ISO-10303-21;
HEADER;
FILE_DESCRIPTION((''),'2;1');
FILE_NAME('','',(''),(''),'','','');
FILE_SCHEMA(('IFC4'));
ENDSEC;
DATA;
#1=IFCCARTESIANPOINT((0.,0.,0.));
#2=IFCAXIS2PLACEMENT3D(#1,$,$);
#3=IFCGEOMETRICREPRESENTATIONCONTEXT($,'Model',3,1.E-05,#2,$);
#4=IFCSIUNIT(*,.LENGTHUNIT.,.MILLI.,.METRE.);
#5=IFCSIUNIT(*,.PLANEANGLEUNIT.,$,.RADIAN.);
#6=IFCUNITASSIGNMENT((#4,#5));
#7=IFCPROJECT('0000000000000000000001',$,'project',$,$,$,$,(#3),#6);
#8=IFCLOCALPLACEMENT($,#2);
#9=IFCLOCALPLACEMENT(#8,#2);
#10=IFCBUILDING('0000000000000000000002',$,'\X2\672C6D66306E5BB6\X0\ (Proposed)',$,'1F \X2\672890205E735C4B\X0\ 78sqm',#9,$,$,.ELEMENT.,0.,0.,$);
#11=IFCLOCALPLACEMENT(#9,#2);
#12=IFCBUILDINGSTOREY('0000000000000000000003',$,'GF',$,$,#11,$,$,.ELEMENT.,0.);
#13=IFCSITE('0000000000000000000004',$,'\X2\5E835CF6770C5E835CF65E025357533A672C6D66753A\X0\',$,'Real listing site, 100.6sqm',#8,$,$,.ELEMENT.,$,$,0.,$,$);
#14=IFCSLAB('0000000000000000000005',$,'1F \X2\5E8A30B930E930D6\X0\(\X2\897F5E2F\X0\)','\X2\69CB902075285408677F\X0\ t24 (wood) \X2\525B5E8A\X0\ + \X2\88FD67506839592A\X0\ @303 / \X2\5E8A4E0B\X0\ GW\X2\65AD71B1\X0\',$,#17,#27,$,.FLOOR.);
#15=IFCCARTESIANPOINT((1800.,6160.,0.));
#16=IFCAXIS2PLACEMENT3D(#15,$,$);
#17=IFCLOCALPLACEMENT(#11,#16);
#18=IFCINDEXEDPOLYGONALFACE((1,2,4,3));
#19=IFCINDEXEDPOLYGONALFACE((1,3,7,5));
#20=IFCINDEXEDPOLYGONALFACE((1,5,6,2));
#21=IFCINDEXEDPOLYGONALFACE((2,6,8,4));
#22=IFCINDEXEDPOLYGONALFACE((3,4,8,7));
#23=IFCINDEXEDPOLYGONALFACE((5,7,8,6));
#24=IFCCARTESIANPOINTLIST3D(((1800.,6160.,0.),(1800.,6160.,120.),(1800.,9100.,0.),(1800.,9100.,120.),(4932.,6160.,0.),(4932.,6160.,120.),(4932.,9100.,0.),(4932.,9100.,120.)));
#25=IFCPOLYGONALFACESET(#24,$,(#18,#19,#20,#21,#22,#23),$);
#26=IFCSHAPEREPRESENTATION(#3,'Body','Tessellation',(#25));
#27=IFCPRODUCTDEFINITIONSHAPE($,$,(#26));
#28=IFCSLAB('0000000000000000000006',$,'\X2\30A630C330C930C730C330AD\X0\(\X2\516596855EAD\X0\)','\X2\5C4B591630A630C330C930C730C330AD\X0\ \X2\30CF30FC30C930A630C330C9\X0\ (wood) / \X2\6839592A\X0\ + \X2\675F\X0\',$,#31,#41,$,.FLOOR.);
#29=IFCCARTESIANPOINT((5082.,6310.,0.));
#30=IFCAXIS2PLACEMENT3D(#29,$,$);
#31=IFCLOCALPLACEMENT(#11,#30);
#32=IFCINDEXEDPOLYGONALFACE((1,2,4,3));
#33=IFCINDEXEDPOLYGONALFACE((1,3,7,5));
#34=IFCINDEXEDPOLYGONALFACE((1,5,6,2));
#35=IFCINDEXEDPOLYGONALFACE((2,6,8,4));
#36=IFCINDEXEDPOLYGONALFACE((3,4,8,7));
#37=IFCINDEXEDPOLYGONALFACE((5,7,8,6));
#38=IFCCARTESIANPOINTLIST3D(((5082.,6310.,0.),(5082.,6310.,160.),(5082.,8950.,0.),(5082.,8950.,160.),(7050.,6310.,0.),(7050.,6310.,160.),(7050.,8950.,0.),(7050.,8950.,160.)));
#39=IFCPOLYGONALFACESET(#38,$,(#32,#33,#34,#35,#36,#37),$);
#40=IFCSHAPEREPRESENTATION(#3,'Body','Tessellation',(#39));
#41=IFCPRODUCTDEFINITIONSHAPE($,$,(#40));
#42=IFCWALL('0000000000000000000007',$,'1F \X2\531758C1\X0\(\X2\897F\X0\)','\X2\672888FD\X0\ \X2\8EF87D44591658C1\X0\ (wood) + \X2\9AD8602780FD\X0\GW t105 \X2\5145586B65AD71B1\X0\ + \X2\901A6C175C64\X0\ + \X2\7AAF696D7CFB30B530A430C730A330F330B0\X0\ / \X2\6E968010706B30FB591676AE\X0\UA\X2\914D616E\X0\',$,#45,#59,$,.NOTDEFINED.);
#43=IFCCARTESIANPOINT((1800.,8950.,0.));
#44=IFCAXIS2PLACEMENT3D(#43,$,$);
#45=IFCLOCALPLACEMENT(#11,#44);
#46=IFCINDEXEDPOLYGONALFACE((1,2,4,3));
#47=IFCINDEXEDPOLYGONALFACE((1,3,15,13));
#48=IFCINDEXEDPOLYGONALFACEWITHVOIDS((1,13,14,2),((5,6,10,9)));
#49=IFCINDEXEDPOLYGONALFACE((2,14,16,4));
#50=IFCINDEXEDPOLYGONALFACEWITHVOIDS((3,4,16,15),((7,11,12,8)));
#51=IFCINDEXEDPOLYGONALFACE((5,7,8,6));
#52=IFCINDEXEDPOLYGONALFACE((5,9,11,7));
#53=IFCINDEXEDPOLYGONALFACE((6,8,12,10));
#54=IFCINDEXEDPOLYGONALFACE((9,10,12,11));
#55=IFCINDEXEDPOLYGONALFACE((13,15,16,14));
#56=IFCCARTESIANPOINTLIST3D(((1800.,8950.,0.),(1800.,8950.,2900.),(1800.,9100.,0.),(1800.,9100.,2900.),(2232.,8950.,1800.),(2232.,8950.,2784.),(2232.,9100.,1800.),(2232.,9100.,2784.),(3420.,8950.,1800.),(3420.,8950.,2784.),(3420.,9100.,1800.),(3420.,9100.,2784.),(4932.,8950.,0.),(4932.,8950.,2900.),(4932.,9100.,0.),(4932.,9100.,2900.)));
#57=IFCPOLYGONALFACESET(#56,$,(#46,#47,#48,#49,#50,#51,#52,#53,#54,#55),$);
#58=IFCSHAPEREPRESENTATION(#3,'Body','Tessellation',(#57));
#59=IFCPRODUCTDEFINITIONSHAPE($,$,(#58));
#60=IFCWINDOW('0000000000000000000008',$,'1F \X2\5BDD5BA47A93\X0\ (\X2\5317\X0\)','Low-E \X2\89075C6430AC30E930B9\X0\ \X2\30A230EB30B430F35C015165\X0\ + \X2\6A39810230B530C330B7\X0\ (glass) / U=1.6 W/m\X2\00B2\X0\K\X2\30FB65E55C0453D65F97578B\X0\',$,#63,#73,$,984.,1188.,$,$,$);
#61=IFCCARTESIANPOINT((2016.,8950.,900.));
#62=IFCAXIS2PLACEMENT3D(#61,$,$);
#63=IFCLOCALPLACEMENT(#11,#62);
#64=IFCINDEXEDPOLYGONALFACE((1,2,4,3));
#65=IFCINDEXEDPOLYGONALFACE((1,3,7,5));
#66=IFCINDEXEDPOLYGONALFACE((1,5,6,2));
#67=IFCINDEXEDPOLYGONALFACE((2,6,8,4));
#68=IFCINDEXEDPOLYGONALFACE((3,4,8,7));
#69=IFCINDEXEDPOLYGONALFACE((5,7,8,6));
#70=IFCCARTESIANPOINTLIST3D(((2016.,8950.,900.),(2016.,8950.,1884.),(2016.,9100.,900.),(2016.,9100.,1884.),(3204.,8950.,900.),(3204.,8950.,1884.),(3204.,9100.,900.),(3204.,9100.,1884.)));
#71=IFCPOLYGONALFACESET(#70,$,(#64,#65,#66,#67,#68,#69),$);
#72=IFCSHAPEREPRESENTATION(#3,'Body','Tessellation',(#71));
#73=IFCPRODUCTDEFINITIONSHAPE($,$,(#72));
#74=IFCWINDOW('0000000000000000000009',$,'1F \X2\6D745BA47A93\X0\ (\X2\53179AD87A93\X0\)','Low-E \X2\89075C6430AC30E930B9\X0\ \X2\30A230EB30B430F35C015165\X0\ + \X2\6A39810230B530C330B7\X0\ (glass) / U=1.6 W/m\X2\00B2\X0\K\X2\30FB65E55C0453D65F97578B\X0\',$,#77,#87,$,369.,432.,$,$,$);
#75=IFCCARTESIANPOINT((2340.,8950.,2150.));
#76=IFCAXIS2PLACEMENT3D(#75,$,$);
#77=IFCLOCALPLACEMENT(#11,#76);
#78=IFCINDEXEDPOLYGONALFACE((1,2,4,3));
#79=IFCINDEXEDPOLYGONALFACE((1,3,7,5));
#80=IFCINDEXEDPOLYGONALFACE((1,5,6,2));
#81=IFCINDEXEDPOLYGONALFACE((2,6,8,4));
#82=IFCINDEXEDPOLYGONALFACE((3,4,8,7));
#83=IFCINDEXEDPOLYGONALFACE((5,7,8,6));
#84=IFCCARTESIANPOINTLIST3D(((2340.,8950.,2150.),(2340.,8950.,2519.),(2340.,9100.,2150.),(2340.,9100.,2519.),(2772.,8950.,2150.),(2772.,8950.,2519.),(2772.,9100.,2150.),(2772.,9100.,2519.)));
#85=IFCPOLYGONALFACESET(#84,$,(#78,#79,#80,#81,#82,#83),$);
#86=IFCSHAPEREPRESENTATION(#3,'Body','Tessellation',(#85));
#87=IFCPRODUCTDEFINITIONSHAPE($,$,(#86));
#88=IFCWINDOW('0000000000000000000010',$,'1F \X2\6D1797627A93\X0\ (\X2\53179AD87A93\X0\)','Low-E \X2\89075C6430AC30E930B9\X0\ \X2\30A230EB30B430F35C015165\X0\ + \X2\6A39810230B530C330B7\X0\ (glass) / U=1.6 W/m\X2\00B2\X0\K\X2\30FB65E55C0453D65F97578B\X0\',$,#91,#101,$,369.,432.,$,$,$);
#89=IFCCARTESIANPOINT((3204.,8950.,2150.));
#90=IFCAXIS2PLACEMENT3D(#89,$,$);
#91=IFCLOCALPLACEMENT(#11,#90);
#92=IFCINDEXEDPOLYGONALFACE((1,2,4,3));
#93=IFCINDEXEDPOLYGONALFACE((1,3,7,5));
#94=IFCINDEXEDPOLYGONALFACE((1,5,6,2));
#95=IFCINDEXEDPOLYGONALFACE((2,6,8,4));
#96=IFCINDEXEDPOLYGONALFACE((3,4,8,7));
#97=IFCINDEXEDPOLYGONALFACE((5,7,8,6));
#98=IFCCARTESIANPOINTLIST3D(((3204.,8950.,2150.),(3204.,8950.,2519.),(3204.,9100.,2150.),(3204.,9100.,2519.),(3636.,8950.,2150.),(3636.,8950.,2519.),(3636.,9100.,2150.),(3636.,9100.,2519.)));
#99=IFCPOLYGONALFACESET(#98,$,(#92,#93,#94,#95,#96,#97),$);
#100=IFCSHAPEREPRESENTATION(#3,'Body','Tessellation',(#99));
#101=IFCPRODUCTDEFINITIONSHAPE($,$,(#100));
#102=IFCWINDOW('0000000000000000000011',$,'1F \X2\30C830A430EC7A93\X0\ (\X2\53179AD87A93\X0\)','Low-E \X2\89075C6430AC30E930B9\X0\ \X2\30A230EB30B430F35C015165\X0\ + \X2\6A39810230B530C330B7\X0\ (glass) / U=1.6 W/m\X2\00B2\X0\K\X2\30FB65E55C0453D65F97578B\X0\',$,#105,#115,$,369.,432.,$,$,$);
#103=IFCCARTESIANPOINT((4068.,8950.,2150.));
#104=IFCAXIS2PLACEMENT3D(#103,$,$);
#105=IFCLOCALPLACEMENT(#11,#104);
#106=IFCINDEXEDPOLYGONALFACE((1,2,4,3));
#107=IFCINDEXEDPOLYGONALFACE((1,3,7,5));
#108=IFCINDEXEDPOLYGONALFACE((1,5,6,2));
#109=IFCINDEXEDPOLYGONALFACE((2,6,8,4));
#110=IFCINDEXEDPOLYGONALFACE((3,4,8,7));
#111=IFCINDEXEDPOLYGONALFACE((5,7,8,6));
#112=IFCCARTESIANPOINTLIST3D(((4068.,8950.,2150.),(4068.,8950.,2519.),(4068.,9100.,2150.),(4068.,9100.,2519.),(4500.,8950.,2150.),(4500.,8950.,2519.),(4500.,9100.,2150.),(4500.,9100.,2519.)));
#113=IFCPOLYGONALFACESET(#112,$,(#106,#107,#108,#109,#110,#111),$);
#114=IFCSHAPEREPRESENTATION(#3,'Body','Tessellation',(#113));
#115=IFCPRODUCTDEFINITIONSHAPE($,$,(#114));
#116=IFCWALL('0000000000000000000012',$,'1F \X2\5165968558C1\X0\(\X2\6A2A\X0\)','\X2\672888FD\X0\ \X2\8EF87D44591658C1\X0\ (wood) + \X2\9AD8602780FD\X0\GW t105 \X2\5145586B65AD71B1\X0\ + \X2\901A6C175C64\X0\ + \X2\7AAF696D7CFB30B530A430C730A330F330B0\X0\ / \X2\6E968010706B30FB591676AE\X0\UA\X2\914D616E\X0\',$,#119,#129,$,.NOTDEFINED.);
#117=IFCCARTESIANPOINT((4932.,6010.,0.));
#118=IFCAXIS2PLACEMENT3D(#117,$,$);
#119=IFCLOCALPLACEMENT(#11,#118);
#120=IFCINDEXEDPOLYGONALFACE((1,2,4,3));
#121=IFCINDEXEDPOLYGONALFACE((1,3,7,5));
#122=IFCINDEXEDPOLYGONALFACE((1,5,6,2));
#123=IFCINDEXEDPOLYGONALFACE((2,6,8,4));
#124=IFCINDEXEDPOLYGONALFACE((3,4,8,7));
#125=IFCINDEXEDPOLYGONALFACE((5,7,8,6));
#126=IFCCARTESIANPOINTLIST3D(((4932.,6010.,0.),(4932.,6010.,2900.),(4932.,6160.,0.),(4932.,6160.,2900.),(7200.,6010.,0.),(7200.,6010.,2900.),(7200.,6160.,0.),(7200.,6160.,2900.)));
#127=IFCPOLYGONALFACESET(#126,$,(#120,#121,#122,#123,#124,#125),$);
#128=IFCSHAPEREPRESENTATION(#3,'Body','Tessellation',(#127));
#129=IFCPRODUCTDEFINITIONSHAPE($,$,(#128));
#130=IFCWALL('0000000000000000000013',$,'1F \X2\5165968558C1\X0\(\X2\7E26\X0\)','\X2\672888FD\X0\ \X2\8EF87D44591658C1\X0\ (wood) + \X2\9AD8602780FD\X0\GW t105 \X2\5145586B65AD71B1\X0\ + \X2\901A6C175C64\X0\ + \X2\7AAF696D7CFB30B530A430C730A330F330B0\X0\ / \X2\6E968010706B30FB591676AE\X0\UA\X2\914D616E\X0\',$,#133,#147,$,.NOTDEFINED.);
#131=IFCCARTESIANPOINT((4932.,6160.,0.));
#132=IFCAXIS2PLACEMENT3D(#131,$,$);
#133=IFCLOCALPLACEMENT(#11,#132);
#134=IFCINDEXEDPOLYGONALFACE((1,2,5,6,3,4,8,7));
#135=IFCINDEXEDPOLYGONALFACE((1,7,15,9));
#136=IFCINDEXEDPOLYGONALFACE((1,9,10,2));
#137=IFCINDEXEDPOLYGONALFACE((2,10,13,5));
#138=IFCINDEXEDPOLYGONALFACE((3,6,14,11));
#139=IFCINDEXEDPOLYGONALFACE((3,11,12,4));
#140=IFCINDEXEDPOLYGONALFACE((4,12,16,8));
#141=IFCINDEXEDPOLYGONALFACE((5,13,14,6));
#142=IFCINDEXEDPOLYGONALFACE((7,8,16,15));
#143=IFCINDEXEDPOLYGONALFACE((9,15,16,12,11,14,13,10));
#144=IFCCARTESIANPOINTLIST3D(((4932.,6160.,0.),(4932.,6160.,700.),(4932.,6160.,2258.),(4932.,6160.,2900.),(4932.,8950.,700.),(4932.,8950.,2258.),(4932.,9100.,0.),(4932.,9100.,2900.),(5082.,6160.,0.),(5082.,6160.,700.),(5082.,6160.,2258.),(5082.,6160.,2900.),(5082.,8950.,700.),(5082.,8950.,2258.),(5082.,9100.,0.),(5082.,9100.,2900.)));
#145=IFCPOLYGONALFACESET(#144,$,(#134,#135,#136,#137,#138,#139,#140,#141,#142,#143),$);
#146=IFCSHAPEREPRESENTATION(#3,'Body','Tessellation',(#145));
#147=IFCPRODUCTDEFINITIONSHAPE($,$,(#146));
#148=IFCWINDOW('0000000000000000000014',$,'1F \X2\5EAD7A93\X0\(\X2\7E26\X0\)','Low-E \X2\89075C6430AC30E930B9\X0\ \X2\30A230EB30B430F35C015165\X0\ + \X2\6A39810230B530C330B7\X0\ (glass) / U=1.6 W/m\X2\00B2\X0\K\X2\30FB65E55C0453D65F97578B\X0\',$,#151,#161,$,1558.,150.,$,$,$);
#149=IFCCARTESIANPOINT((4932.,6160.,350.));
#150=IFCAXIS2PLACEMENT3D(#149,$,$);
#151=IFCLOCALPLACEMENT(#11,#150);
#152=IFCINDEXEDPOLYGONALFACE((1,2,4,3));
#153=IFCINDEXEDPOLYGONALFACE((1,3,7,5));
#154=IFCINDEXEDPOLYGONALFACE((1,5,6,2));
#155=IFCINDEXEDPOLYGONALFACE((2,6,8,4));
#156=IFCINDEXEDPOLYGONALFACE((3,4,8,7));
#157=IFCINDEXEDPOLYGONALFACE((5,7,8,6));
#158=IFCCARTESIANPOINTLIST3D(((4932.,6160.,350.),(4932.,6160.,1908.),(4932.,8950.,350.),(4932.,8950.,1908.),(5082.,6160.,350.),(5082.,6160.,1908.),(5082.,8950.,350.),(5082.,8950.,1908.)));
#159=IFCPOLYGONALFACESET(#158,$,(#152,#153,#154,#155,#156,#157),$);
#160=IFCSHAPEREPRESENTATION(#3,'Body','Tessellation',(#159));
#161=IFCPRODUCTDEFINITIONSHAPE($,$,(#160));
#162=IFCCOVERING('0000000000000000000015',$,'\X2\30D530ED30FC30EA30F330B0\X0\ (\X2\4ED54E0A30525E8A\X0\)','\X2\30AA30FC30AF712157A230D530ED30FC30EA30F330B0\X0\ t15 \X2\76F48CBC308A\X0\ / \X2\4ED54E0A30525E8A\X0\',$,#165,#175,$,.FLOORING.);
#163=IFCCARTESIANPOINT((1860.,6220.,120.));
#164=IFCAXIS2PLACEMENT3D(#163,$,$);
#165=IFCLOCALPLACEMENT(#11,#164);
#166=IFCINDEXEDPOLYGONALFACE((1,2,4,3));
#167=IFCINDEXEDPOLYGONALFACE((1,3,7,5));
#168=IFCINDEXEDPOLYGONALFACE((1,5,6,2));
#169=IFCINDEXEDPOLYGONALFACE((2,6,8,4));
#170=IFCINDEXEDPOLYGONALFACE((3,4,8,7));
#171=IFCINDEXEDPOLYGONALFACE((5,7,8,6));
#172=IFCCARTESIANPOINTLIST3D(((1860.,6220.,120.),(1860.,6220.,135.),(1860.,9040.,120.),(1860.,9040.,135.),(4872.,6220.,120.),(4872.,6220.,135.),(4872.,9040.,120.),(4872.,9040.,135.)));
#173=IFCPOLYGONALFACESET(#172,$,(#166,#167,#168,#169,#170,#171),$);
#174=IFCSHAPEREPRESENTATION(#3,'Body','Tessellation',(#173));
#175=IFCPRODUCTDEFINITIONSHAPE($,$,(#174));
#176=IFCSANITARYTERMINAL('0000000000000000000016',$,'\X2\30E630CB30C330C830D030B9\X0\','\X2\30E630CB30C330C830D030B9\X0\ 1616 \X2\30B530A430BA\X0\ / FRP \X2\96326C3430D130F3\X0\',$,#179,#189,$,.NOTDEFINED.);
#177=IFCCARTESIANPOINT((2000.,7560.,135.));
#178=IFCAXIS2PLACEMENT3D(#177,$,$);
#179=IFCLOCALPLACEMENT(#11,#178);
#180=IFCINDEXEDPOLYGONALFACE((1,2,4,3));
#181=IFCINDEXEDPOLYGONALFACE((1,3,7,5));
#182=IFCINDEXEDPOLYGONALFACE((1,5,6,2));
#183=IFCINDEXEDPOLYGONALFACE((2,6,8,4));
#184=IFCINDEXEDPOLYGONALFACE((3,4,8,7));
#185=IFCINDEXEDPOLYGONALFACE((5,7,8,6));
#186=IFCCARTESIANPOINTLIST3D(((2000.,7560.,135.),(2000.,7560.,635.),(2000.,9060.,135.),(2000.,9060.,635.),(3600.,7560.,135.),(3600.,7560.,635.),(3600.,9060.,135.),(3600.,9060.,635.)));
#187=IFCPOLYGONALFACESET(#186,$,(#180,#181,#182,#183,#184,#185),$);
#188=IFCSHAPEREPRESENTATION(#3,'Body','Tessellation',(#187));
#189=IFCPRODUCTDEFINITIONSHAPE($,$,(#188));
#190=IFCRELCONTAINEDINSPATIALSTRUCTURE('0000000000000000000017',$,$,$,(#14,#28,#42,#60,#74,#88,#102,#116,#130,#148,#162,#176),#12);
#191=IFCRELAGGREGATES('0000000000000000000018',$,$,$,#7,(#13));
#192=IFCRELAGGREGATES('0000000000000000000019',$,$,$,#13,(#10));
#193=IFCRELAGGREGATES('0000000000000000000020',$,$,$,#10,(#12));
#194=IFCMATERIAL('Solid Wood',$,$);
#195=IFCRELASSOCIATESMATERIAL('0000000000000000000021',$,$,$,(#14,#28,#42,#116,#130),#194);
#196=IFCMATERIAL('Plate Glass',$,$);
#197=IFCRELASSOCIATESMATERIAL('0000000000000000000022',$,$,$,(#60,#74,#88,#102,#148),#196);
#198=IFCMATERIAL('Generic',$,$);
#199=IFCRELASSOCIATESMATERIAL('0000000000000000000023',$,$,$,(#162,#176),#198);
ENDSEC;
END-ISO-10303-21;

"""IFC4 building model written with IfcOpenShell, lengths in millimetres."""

from ifc_helpers import new_model, si_unit, frame, frame_2d, origin, place, context, project, spatial, rectangle, extrude, material, element, fill, save


model = new_model("IFC4")

# Units and contexts
model_context = context("Model", 3, precision=1e-05, world=origin())
ifc_project = project(units=[si_unit("LENGTHUNIT", "METRE", prefix="MILLI"), si_unit("PLANEANGLEUNIT", "RADIAN")], contexts=[model_context])

# Site, building, storey
site_placement = place(None, origin())
site = spatial("IfcSite", under=ifc_project, at=site_placement, Name="広島県広島市南区本浦町", ObjectType="Real listing site, 100.6sqm", CompositionType="ELEMENT", RefElevation=0.0)
building_placement = place(site_placement, origin())
building = spatial("IfcBuilding", under=site, at=building_placement, Name="本浦の家 (Proposed)", ObjectType="1F 木造平屋 78sqm", CompositionType="ELEMENT", ElevationOfRefHeight=0.0, ElevationOfTerrain=0.0)
storey_placement = place(building_placement, origin())
storey = spatial("IfcBuildingStorey", under=building, at=storey_placement, Name="GF", CompositionType="ELEMENT", Elevation=0.0)

# Slabs
ifc_material_1 = material(Name="Solid Wood")
slab_1_placement = place(storey_placement, frame((1800.0, 6160.0, 0.0)))
element("IfcSlab", 1, at=slab_1_placement, inside=storey, material=ifc_material_1, Name="1F 床スラブ(西帯)", Description="構造用合板 t24 (wood) 剛床 + 製材根太 @303 / 床下 GW断熱", PredefinedType="FLOOR", context=model_context, shape_type="SweptSolid", body=[
    extrude(rectangle(XDim=3132.0, YDim=2940.0, at=frame_2d((1566.0, 1470.0))), frame((1800.0, 6160.0, 0.0)), (0.0, 0.0, 1.0), 120.0),
])
slab_2_placement = place(storey_placement, frame((5082.0, 6310.0, 0.0)))
element("IfcSlab", 2, at=slab_2_placement, inside=storey, material=ifc_material_1, Name="ウッドデッキ(入隅庭)", Description="屋外ウッドデッキ ハードウッド (wood) / 根太 + 束", PredefinedType="FLOOR", context=model_context, shape_type="SweptSolid", body=[
    extrude(rectangle(XDim=1968.0, YDim=2640.0, at=frame_2d((984.0, 1320.0))), frame((5082.0, 6310.0, 0.0)), (0.0, 0.0, 1.0), 160.0),
])

# Wall, openings, windows
wall_1_placement = place(storey_placement, frame((1800.0, 8950.0, 0.0)))
wall_1 = element("IfcWall", 3, at=wall_1_placement, inside=storey, material=ifc_material_1, Name="1F 北壁(西)", Description="木製 軸組外壁 (wood) + 高性能GW t105 充填断熱 + 通気層 + 窯業系サイディング / 準耐火・外皮UA配慮", PredefinedType="NOTDEFINED", context=model_context, shape_type="SweptSolid", body=[
    extrude(rectangle(XDim=3132.0, YDim=150.0, at=frame_2d((1566.0, 75.0))), frame((1800.0, 8950.0, 0.0)), (0.0, 0.0, 1.0), 2900.0),
])
opening_1_placement = place(storey_placement, frame((2016.0, 8950.0, 900.0)))
opening_1 = element("IfcOpeningElement", 4, at=opening_1_placement, cuts=wall_1, PredefinedType="NOTDEFINED", context=model_context, shape_type="SweptSolid", body=[
    extrude(rectangle(XDim=1188.0, YDim=150.0, at=frame_2d((594.0, 75.0))), frame((2016.0, 8950.0, 900.0)), (0.0, 0.0, 1.0), 984.0),
])
opening_2_placement = place(storey_placement, frame((2340.0, 8950.0, 2150.0)))
opening_2 = element("IfcOpeningElement", 5, at=opening_2_placement, cuts=wall_1, PredefinedType="NOTDEFINED", context=model_context, shape_type="SweptSolid", body=[
    extrude(rectangle(XDim=432.0, YDim=150.0, at=frame_2d((216.0, 75.0))), frame((2340.0, 8950.0, 2150.0)), (0.0, 0.0, 1.0), 369.0),
])
opening_3_placement = place(storey_placement, frame((3204.0, 8950.0, 2150.0)))
opening_3 = element("IfcOpeningElement", 6, at=opening_3_placement, cuts=wall_1, PredefinedType="NOTDEFINED", context=model_context, shape_type="SweptSolid", body=[
    extrude(rectangle(XDim=432.0, YDim=150.0, at=frame_2d((216.0, 75.0))), frame((3204.0, 8950.0, 2150.0)), (0.0, 0.0, 1.0), 369.0),
])
opening_4_placement = place(storey_placement, frame((4068.0, 8950.0, 2150.0)))
opening_4 = element("IfcOpeningElement", 7, at=opening_4_placement, cuts=wall_1, PredefinedType="NOTDEFINED", context=model_context, shape_type="SweptSolid", body=[
    extrude(rectangle(XDim=432.0, YDim=150.0, at=frame_2d((216.0, 75.0))), frame((4068.0, 8950.0, 2150.0)), (0.0, 0.0, 1.0), 369.0),
])
ifc_material_2 = material(Name="Plate Glass")
window_1_placement = place(storey_placement, frame((2016.0, 8950.0, 900.0)))
window_1 = element("IfcWindow", 8, at=window_1_placement, inside=storey, material=ifc_material_2, Name="1F 寝室窓 (北)", Description="Low-E 複層ガラス アルゴン封入 + 樹脂サッシ (glass) / U=1.6 W/m²K・日射取得型", OverallHeight=984.0, OverallWidth=1188.0, context=model_context, shape_type="SweptSolid", body=[
    extrude(rectangle(XDim=1188.0, YDim=150.0, at=frame_2d((594.0, 75.0))), frame((2016.0, 8950.0, 900.0)), (0.0, 0.0, 1.0), 984.0),
])
fill(opening_1, window_1)
window_2_placement = place(storey_placement, frame((2340.0, 8950.0, 2150.0)))
window_2 = element("IfcWindow", 9, at=window_2_placement, inside=storey, material=ifc_material_2, Name="1F 浴室窓 (北高窓)", Description="Low-E 複層ガラス アルゴン封入 + 樹脂サッシ (glass) / U=1.6 W/m²K・日射取得型", OverallHeight=369.0, OverallWidth=432.0, context=model_context, shape_type="SweptSolid", body=[
    extrude(rectangle(XDim=432.0, YDim=150.0, at=frame_2d((216.0, 75.0))), frame((2340.0, 8950.0, 2150.0)), (0.0, 0.0, 1.0), 369.0),
])
fill(opening_2, window_2)
window_3_placement = place(storey_placement, frame((3204.0, 8950.0, 2150.0)))
window_3 = element("IfcWindow", 10, at=window_3_placement, inside=storey, material=ifc_material_2, Name="1F 洗面窓 (北高窓)", Description="Low-E 複層ガラス アルゴン封入 + 樹脂サッシ (glass) / U=1.6 W/m²K・日射取得型", OverallHeight=369.0, OverallWidth=432.0, context=model_context, shape_type="SweptSolid", body=[
    extrude(rectangle(XDim=432.0, YDim=150.0, at=frame_2d((216.0, 75.0))), frame((3204.0, 8950.0, 2150.0)), (0.0, 0.0, 1.0), 369.0),
])
fill(opening_3, window_3)
window_4_placement = place(storey_placement, frame((4068.0, 8950.0, 2150.0)))
window_4 = element("IfcWindow", 11, at=window_4_placement, inside=storey, material=ifc_material_2, Name="1F トイレ窓 (北高窓)", Description="Low-E 複層ガラス アルゴン封入 + 樹脂サッシ (glass) / U=1.6 W/m²K・日射取得型", OverallHeight=369.0, OverallWidth=432.0, context=model_context, shape_type="SweptSolid", body=[
    extrude(rectangle(XDim=432.0, YDim=150.0, at=frame_2d((216.0, 75.0))), frame((4068.0, 8950.0, 2150.0)), (0.0, 0.0, 1.0), 369.0),
])
fill(opening_4, window_4)

# Wall
wall_2_placement = place(storey_placement, frame((4932.0, 6010.0, 0.0)))
element("IfcWall", 12, at=wall_2_placement, inside=storey, material=ifc_material_1, Name="1F 入隅壁(横)", Description="木製 軸組外壁 (wood) + 高性能GW t105 充填断熱 + 通気層 + 窯業系サイディング / 準耐火・外皮UA配慮", PredefinedType="NOTDEFINED", context=model_context, shape_type="SweptSolid", body=[
    extrude(rectangle(XDim=2268.0, YDim=150.0, at=frame_2d((1134.0, 75.0))), frame((4932.0, 6010.0, 0.0)), (0.0, 0.0, 1.0), 2900.0),
])

# Wall, opening, window
wall_3_placement = place(storey_placement, frame((4932.0, 6160.0, 0.0)))
wall_3 = element("IfcWall", 13, at=wall_3_placement, inside=storey, material=ifc_material_1, Name="1F 入隅壁(縦)", Description="木製 軸組外壁 (wood) + 高性能GW t105 充填断熱 + 通気層 + 窯業系サイディング / 準耐火・外皮UA配慮", PredefinedType="NOTDEFINED", context=model_context, shape_type="SweptSolid", body=[
    extrude(rectangle(XDim=150.0, YDim=2940.0, at=frame_2d((75.0, 1470.0))), frame((4932.0, 6160.0, 0.0)), (0.0, 0.0, 1.0), 2900.0),
])
opening_5_placement = place(storey_placement, frame((4932.0, 6160.0, 350.0)))
opening_5 = element("IfcOpeningElement", 14, at=opening_5_placement, cuts=wall_3, PredefinedType="NOTDEFINED", context=model_context, shape_type="SweptSolid", body=[
    extrude(rectangle(XDim=150.0, YDim=2790.0, at=frame_2d((75.0, 1395.0))), frame((4932.0, 6160.0, 350.0)), (0.0, 0.0, 1.0), 1558.0),
])
window_5_placement = place(storey_placement, frame((4932.0, 6160.0, 350.0)))
window_5 = element("IfcWindow", 15, at=window_5_placement, inside=storey, material=ifc_material_2, Name="1F 庭窓(縦)", Description="Low-E 複層ガラス アルゴン封入 + 樹脂サッシ (glass) / U=1.6 W/m²K・日射取得型", OverallHeight=1558.0, OverallWidth=150.0, context=model_context, shape_type="SweptSolid", body=[
    extrude(rectangle(XDim=150.0, YDim=2790.0, at=frame_2d((75.0, 1395.0))), frame((4932.0, 6160.0, 350.0)), (0.0, 0.0, 1.0), 1558.0),
])
fill(opening_5, window_5)

# Covering
ifc_material_3 = material(Name="Generic")
covering_placement = place(storey_placement, frame((1860.0, 6220.0, 120.0)))
element("IfcCovering", 16, at=covering_placement, inside=storey, material=ifc_material_3, Name="フローリング (仕上げ床)", Description="オーク無垢フローリング t15 直貼り / 仕上げ床", PredefinedType="FLOORING", context=model_context, shape_type="SweptSolid", body=[
    extrude(rectangle(XDim=3012.0, YDim=2820.0, at=frame_2d((1506.0, 1410.0))), frame((1860.0, 6220.0, 120.0)), (0.0, 0.0, 1.0), 15.0),
])

# Sanitary terminal
sanitary_terminal_1_placement = place(storey_placement, frame((2000.0, 7560.0, 135.0)))
element("IfcSanitaryTerminal", 17, at=sanitary_terminal_1_placement, inside=storey, material=ifc_material_3, Name="ユニットバス", Description="ユニットバス 1616 サイズ / FRP 防水パン", PredefinedType="NOTDEFINED", context=model_context, shape_type="SweptSolid", body=[
    extrude(rectangle(XDim=1600.0, YDim=1500.0, at=frame_2d((800.0, 750.0))), frame((2000.0, 7560.0, 135.0)), (0.0, 0.0, 1.0), 500.0),
])

save(model, "model.ifc")
